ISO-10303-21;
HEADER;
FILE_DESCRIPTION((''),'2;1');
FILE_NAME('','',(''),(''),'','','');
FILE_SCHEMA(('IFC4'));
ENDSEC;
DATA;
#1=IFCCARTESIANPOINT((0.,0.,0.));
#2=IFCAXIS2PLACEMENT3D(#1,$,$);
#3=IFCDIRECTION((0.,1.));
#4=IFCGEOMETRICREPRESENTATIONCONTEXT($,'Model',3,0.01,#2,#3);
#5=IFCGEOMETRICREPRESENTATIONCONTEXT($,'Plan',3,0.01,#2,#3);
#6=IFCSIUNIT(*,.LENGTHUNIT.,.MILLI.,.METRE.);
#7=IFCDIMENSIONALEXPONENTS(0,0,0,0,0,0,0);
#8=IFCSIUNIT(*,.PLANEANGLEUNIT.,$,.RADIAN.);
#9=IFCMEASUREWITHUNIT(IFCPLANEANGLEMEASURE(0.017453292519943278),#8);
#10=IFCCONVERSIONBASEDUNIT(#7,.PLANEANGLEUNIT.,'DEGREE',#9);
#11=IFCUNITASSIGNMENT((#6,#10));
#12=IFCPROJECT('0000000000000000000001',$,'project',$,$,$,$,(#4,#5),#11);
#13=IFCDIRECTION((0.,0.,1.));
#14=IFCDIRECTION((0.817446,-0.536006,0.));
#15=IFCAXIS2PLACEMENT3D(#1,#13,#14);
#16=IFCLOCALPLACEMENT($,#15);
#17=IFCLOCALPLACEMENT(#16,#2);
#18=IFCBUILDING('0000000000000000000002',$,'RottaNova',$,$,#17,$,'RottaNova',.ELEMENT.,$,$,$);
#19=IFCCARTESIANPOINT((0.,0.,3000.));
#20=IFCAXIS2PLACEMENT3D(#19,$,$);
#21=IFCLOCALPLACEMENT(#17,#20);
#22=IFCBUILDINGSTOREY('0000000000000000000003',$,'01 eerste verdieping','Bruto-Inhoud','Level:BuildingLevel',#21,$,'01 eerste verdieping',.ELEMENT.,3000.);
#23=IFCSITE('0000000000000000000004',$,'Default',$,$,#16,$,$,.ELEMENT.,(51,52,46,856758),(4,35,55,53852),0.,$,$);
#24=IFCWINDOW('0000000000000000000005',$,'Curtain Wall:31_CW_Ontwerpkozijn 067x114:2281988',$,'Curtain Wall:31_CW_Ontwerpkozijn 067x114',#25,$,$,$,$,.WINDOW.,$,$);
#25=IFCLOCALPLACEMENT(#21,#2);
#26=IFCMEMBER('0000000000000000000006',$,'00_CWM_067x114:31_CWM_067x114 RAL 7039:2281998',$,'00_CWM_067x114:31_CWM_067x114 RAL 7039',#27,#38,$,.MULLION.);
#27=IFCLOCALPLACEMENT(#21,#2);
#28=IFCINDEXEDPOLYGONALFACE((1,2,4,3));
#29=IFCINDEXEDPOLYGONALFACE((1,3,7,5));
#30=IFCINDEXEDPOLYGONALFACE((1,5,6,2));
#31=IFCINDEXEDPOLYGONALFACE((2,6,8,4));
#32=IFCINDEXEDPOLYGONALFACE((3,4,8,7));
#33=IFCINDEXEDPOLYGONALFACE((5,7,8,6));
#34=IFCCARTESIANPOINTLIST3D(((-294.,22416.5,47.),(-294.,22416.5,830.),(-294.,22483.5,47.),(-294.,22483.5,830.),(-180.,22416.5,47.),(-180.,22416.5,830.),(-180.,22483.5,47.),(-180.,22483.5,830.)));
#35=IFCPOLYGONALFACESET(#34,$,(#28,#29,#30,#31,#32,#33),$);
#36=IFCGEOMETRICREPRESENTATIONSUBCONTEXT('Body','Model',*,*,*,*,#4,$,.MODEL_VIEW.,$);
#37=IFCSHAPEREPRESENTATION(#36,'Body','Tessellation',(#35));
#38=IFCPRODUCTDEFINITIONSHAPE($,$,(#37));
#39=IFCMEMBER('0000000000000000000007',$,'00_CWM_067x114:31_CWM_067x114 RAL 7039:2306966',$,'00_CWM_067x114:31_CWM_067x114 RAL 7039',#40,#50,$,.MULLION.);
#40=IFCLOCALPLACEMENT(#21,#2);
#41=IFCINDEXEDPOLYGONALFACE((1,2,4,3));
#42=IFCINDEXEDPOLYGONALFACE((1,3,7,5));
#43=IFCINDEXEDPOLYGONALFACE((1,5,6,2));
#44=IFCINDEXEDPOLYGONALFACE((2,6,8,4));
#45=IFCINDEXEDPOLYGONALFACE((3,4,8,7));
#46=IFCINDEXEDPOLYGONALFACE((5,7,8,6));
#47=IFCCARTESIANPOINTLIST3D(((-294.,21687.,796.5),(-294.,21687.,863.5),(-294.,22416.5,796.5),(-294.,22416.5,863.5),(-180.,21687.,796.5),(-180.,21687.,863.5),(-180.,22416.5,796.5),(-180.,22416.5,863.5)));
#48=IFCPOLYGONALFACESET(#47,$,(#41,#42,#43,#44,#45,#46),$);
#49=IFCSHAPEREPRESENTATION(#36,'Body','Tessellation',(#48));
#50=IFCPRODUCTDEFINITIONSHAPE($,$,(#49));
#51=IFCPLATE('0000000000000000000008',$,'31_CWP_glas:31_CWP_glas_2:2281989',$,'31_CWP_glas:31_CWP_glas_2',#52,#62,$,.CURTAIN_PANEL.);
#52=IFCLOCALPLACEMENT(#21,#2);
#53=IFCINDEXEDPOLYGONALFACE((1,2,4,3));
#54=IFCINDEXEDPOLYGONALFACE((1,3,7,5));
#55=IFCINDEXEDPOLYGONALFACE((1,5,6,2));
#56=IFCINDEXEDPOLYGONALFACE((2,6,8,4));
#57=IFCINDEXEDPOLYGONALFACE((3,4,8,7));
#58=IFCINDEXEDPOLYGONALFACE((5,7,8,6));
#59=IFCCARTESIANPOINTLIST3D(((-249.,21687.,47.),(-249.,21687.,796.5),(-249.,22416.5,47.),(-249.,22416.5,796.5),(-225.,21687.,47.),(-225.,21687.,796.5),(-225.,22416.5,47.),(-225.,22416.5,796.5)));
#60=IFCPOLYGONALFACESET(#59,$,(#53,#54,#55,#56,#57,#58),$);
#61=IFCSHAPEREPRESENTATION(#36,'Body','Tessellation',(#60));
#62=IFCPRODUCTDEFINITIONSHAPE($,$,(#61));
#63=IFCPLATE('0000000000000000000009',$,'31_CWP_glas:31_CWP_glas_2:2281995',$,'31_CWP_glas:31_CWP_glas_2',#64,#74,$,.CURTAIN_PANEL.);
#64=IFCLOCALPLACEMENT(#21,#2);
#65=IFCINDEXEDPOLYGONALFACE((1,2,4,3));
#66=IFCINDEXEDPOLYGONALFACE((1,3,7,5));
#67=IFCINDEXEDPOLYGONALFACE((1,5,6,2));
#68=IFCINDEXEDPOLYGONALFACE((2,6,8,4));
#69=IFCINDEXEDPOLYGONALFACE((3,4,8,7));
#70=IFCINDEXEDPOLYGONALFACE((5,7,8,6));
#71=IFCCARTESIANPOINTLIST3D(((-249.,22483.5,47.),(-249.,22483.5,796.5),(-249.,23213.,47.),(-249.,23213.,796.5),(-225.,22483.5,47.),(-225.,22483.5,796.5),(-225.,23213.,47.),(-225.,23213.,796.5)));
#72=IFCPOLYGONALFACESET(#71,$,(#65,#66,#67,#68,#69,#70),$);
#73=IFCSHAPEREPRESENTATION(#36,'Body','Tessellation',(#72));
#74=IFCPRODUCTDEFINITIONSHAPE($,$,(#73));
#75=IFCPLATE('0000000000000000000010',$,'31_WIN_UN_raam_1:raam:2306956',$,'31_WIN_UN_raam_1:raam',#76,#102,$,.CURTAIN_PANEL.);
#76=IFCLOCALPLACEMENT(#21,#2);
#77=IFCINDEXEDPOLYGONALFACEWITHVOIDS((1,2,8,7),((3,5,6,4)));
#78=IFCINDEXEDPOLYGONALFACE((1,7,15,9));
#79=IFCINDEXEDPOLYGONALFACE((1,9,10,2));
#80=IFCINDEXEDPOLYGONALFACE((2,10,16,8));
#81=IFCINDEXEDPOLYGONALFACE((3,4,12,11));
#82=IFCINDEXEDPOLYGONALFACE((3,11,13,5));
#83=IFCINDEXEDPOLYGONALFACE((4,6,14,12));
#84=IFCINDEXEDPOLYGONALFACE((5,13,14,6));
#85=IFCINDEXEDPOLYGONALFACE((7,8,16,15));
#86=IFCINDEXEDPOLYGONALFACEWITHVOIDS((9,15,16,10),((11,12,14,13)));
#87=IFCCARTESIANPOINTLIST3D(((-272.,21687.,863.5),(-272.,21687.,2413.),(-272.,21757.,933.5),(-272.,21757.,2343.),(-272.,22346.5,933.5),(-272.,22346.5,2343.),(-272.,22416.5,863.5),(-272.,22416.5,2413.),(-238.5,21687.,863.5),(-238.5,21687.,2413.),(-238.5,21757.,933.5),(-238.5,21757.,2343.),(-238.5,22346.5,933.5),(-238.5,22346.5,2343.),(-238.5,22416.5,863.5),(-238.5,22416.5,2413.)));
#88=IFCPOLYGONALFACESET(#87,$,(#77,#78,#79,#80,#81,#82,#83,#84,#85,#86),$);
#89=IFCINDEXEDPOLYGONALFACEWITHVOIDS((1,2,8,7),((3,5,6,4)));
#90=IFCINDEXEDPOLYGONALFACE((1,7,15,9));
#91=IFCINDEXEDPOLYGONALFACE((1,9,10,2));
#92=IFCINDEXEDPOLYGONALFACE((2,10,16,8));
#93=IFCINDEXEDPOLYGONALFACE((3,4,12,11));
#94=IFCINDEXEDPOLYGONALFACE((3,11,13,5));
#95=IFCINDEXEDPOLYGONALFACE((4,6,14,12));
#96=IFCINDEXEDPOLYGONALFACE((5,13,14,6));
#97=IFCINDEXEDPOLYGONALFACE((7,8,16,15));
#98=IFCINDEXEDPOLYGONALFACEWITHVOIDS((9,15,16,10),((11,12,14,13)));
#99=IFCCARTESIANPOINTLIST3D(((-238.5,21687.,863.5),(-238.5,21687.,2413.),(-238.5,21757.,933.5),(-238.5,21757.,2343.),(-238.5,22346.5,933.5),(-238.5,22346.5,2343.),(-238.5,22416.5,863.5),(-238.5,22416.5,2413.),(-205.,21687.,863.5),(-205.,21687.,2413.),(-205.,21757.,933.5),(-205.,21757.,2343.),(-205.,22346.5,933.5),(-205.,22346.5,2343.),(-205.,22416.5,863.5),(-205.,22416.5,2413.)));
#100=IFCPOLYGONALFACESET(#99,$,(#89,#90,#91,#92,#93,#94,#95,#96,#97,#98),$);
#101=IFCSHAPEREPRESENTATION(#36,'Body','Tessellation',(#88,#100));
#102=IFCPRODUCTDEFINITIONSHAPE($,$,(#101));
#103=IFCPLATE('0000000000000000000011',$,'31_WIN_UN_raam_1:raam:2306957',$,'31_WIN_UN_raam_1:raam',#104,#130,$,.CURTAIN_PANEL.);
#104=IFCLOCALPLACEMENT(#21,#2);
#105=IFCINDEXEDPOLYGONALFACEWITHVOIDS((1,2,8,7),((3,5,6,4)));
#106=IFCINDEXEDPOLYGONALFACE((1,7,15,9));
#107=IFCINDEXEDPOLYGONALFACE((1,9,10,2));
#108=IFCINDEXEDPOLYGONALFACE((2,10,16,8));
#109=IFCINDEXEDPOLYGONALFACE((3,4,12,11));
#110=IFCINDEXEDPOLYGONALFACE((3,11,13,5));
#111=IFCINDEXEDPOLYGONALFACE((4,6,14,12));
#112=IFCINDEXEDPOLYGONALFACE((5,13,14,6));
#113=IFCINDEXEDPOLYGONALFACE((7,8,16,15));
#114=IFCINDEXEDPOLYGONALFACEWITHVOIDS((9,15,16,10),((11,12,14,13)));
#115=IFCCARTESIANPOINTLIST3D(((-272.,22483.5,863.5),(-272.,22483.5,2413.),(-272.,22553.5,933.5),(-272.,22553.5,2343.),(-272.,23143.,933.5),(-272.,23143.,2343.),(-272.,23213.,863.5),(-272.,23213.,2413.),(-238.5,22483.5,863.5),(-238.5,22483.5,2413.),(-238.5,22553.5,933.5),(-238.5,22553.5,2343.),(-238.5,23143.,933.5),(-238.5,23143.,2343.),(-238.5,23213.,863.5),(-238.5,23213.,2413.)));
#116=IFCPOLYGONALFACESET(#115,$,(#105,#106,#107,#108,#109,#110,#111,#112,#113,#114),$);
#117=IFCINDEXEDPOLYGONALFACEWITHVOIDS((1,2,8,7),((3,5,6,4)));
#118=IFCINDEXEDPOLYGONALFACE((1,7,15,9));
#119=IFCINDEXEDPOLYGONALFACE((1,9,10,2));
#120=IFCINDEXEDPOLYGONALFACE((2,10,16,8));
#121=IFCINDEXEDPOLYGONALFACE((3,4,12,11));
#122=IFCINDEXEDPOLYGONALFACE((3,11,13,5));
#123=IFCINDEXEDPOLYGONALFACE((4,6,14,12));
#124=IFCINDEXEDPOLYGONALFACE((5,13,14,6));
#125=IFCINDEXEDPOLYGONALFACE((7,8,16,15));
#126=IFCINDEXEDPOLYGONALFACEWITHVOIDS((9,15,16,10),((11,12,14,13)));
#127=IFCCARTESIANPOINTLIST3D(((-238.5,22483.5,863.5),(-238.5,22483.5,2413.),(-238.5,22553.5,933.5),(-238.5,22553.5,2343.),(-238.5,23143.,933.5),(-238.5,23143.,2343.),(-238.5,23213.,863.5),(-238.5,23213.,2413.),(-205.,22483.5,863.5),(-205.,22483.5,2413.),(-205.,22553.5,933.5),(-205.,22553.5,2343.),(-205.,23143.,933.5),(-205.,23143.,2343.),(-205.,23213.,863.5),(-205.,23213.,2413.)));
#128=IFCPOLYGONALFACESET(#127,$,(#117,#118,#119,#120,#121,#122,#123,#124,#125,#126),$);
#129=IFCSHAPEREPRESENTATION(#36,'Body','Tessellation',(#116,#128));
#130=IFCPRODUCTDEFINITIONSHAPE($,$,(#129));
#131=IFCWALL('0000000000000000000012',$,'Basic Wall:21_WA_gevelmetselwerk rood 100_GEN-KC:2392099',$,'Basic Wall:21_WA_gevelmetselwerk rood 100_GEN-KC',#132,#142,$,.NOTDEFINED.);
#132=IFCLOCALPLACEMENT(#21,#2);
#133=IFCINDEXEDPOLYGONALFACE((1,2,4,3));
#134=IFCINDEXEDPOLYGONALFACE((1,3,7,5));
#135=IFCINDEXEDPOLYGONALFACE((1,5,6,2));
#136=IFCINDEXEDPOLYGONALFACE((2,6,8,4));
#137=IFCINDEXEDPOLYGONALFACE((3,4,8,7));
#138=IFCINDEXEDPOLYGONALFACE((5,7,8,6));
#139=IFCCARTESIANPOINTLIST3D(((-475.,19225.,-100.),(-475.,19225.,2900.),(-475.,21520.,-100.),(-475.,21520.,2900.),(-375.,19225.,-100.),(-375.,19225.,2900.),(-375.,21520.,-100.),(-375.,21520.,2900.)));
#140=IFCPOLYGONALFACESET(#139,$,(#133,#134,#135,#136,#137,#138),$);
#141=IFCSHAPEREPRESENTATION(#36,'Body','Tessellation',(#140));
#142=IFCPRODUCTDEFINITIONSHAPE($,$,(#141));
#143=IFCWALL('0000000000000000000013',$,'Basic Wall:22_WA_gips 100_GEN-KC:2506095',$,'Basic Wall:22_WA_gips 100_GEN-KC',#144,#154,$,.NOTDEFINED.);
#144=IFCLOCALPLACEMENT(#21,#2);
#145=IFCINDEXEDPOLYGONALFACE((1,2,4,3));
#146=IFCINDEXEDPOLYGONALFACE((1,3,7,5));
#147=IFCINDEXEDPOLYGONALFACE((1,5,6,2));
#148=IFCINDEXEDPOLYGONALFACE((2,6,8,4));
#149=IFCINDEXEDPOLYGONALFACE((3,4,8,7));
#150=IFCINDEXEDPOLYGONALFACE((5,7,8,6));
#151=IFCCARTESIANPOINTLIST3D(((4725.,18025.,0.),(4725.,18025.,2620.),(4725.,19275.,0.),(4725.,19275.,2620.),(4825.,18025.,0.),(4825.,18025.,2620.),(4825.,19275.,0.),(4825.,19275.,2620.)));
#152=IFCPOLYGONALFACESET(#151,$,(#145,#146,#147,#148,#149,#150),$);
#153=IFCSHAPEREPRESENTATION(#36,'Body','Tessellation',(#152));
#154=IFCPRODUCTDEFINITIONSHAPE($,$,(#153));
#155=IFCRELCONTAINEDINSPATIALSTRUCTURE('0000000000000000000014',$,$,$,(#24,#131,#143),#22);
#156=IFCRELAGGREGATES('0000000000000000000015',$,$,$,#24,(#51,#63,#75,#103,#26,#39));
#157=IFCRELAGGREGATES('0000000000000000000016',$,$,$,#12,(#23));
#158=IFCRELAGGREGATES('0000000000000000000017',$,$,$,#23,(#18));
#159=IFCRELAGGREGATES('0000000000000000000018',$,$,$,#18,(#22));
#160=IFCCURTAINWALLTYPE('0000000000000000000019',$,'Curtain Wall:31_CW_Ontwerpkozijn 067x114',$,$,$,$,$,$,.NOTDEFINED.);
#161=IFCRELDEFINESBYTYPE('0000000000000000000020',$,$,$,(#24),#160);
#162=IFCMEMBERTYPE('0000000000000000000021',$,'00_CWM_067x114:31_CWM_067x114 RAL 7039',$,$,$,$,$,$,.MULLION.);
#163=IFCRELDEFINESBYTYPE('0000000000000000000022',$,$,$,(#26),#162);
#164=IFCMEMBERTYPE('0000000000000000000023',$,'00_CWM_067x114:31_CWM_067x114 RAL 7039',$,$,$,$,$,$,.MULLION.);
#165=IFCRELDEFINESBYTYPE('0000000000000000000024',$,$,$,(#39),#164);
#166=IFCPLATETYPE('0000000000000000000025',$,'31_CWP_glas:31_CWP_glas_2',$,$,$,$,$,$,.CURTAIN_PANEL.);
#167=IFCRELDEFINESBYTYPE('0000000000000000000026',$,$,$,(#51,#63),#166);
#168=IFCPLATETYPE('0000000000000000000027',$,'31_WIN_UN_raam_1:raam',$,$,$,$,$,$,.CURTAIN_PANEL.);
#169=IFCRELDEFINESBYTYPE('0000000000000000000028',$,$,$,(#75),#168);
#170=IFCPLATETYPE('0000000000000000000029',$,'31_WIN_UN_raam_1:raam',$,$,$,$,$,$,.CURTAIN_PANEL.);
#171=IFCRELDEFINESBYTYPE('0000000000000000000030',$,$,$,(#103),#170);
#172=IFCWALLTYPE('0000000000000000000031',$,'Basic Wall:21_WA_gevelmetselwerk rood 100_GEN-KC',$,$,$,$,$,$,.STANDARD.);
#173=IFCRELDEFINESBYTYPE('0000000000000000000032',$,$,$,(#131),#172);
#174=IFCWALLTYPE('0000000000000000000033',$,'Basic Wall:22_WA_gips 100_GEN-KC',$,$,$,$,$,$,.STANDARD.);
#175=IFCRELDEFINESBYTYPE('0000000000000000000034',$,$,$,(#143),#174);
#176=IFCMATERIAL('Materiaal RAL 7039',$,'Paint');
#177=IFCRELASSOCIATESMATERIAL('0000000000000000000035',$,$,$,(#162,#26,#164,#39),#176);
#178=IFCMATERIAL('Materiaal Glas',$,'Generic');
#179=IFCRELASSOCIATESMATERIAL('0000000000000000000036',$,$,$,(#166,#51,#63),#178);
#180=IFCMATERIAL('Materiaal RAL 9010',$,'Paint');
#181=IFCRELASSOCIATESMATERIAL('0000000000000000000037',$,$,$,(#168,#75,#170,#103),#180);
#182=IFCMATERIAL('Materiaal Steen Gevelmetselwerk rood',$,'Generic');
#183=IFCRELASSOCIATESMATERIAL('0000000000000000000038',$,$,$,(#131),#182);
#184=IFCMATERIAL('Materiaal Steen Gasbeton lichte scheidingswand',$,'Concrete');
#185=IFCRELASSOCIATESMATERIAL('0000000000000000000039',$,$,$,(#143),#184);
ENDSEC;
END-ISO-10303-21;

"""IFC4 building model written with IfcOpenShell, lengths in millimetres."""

from ifc_helpers import new_model, entity, si_unit, converted_unit, direction, frame, origin, place, context, subcontext, project, spatial, indexed_curve, outline, extrude, source, transform, mapped, material, type_object, type_shapes, element, aggregate, save


model = new_model("IFC4")

# Units and contexts
model_context = context("Model", 3, precision=0.01, world=origin(), true_north=direction((0.0, 1.0)))
plan_context = context("Plan", 3, precision=0.01, world=origin(), true_north=direction((0.0, 1.0)))
body_context = subcontext(model_context, "Body", "Model", "MODEL_VIEW")
ifc_project = project(units=[si_unit("LENGTHUNIT", "METRE", prefix="MILLI"), converted_unit("PLANEANGLEUNIT", "DEGREE", entity("IfcPlaneAngleMeasure", 0.017453292519943278), si_unit("PLANEANGLEUNIT", "RADIAN"), dimensions=[0, 0, 0, 0, 0, 0, 0])], contexts=[model_context, plan_context])

# Site, building, storey
site_placement = place(None, frame((0.0, 0.0, 0.0), z_axis=(0.0, 0.0, 1.0), x_axis=(0.817446, -0.536006, 0.0)))
site = spatial("IfcSite", under=ifc_project, at=site_placement, Name="Default", CompositionType="ELEMENT", RefLatitude=(51, 52, 46, 856758), RefLongitude=(4, 35, 55, 53852), RefElevation=0.0)
building_placement = place(site_placement, origin())
building = spatial("IfcBuilding", under=site, at=building_placement, Name="RottaNova", LongName="RottaNova", CompositionType="ELEMENT")
storey_placement = place(building_placement, frame((0.0, 0.0, 3000.0)))
storey = spatial("IfcBuildingStorey", under=building, at=storey_placement, Name="01 eerste verdieping", Description="Bruto-Inhoud", ObjectType="Level:BuildingLevel", LongName="01 eerste verdieping", CompositionType="ELEMENT", Elevation=3000.0)

# Shared definitions
curtain_wall_type = type_object("IfcCurtainWallType", Name="Curtain Wall:31_CW_Ontwerpkozijn 067x114", PredefinedType="NOTDEFINED")
ifc_material_1 = material(Name="Materiaal RAL 7039", Category="Paint")

# Window
window_1_placement = place(storey_placement, frame((0.0, 0.0, -3000.0)))
window_1 = element("IfcWindow", 1, at=window_1_placement, inside=storey, type_object=curtain_wall_type, Name="Curtain Wall:31_CW_Ontwerpkozijn 067x114:2281988", ObjectType="Curtain Wall:31_CW_Ontwerpkozijn 067x114", PredefinedType="WINDOW")

# Members
member_type_1 = type_object("IfcMemberType", Name="00_CWM_067x114:31_CWM_067x114 RAL 7039", PredefinedType="MULLION", material=ifc_material_1)
shared_shape_1 = source(origin(), body_context, "Body", "SweptSolid", [
    extrude(outline(indexed_curve([(-33.5, -57.0), (33.5, -57.0), (33.5, 57.0), (-33.5, 57.0), (-33.5, -57.0)], self_intersect=False)), frame((0.0, -57.0, -783.0), z_axis=(0.0, 0.0, 1.0), x_axis=(-1.0, 0.0, 0.0)), (0.0, 0.0, 1.0), 783.0),
])
type_shapes(member_type_1, [shared_shape_1])
member_1_placement = place(window_1_placement, frame((-180.0, 22450.0, 3047.0), z_axis=(0.0, 0.0, -1.0), x_axis=(0.0, 1.0, 0.0)))
member_1 = element("IfcMember", 2, at=member_1_placement, type_object=member_type_1, material=ifc_material_1, Name="00_CWM_067x114:31_CWM_067x114 RAL 7039:2281998", ObjectType="00_CWM_067x114:31_CWM_067x114 RAL 7039", PredefinedType="MULLION", context=body_context, shape_type="MappedRepresentation", body=[
    mapped(shared_shape_1, transform((0.0, 0.0, 0.0), scale=1.0)),
])
member_type_2 = type_object("IfcMemberType", Name="00_CWM_067x114:31_CWM_067x114 RAL 7039", PredefinedType="MULLION", material=ifc_material_1)
shared_shape_2 = source(origin(), body_context, "Body", "SweptSolid", [
    extrude(outline(indexed_curve([(-33.5, -57.0), (33.5, -57.0), (33.5, 57.0), (-33.5, 57.0), (-33.5, -57.0)], self_intersect=False)), frame((0.0, -57.0, -729.5), z_axis=(0.0, 0.0, 1.0), x_axis=(-1.0, 0.0, 0.0)), (0.0, 0.0, 1.0), 729.5),
])
type_shapes(member_type_2, [shared_shape_2])
member_2_placement = place(window_1_placement, frame((-180.0, 22416.5, 3830.0), z_axis=(0.0, 1.0, 0.0), x_axis=(0.0, 0.0, 1.0)))
member_2 = element("IfcMember", 3, at=member_2_placement, type_object=member_type_2, material=ifc_material_1, Name="00_CWM_067x114:31_CWM_067x114 RAL 7039:2306966", ObjectType="00_CWM_067x114:31_CWM_067x114 RAL 7039", PredefinedType="MULLION", context=body_context, shape_type="MappedRepresentation", body=[
    mapped(shared_shape_2, transform((0.0, 0.0, 0.0), scale=1.0)),
])

# Plates
ifc_material_2 = material(Name="Materiaal Glas", Category="Generic")
plate_type_1 = type_object("IfcPlateType", Name="31_CWP_glas:31_CWP_glas_2", PredefinedType="CURTAIN_PANEL", material=ifc_material_2)
shared_shape_3 = source(origin(), body_context, "Body", "SweptSolid", [
    extrude(outline(indexed_curve([(-12.0, -364.7), (12.0, -364.7), (12.0, 364.7), (-12.0, 364.7), (-12.0, -364.7)], self_intersect=False)), frame((0.0, 57.0, 0.0), z_axis=(0.0, 0.0, 1.0), x_axis=(0.0, 1.0, 0.0)), (0.0, 0.0, 1.0), 749.5),
])
type_shapes(plate_type_1, [shared_shape_3])
plate_1_placement = place(window_1_placement, frame((-180.0, 22051.7, 3047.0), z_axis=(0.0, 0.0, 1.0), x_axis=(0.0, 1.0, 0.0)))
plate_1 = element("IfcPlate", 4, at=plate_1_placement, type_object=plate_type_1, material=ifc_material_2, Name="31_CWP_glas:31_CWP_glas_2:2281989", ObjectType="31_CWP_glas:31_CWP_glas_2", PredefinedType="CURTAIN_PANEL", context=body_context, shape_type="MappedRepresentation", body=[
    mapped(shared_shape_3, transform((0.0, 0.0, 0.0), scale=1.0)),
])
plate_2_placement = place(window_1_placement, frame((-180.0, 22848.2, 3047.0), z_axis=(0.0, 0.0, 1.0), x_axis=(0.0, 1.0, 0.0)))
plate_2 = element("IfcPlate", 5, at=plate_2_placement, type_object=plate_type_1, material=ifc_material_2, Name="31_CWP_glas:31_CWP_glas_2:2281995", ObjectType="31_CWP_glas:31_CWP_glas_2", PredefinedType="CURTAIN_PANEL", context=body_context, shape_type="MappedRepresentation", body=[
    mapped(shared_shape_3, transform((0.0, 0.0, 0.0), scale=1.0)),
])
ifc_material_3 = material(Name="Materiaal RAL 9010", Category="Paint")
plate_type_2 = type_object("IfcPlateType", Name="31_WIN_UN_raam_1:raam", PredefinedType="CURTAIN_PANEL", material=ifc_material_3)
shared_shape_4 = source(origin(), body_context, "Body", "SweptSolid", [
    extrude(outline(indexed_curve([(-364.7, -774.7), (364.7, -774.7), (364.7, 774.7), (-364.7, 774.7), (-364.7, -774.7)], self_intersect=False), holes=[indexed_curve([(-294.7, 704.7), (294.7, 704.7), (294.7, -704.8), (-294.7, -704.8), (-294.7, 704.7)], self_intersect=False)]), frame((0.0, 58.5, 774.8), z_axis=(0.0, 1.0, 0.0), x_axis=(1.0, 0.0, 0.0)), (0.0, 0.0, 1.0), 33.5),
    extrude(outline(indexed_curve([(-364.7, -774.7), (364.7, -774.7), (364.7, 774.7), (-364.7, 774.7), (-364.7, -774.7)], self_intersect=False), holes=[indexed_curve([(-294.7, 704.7), (294.7, 704.7), (294.7, -704.8), (-294.7, -704.8), (-294.7, 704.7)], self_intersect=False)]), frame((0.0, 25.0, 774.8), z_axis=(0.0, 1.0, 0.0), x_axis=(1.0, 0.0, 0.0)), (0.0, 0.0, 1.0), 33.5),
])
type_shapes(plate_type_2, [shared_shape_4])
plate_3_placement = place(window_1_placement, frame((-180.0, 22051.7, 3863.5), z_axis=(0.0, 0.0, 1.0), x_axis=(0.0, 1.0, 0.0)))
plate_3 = element("IfcPlate", 6, at=plate_3_placement, type_object=plate_type_2, material=ifc_material_3, Name="31_WIN_UN_raam_1:raam:2306956", ObjectType="31_WIN_UN_raam_1:raam", PredefinedType="CURTAIN_PANEL", context=body_context, shape_type="MappedRepresentation", body=[
    mapped(shared_shape_4, transform((0.0, 0.0, 0.0), scale=1.0)),
])
plate_type_3 = type_object("IfcPlateType", Name="31_WIN_UN_raam_1:raam", PredefinedType="CURTAIN_PANEL", material=ifc_material_3)
shared_shape_5 = source(origin(), body_context, "Body", "SweptSolid", [
    extrude(outline(indexed_curve([(-364.7, -774.7), (364.7, -774.7), (364.7, 774.7), (-364.7, 774.7), (-364.7, -774.7)], self_intersect=False), holes=[indexed_curve([(-294.7, 704.7), (294.7, 704.7), (294.7, -704.8), (-294.7, -704.8), (-294.7, 704.7)], self_intersect=False)]), frame((0.0, 58.5, 774.8), z_axis=(0.0, 1.0, 0.0), x_axis=(1.0, 0.0, 0.0)), (0.0, 0.0, 1.0), 33.5),
    extrude(outline(indexed_curve([(-364.7, -774.7), (364.7, -774.7), (364.7, 774.7), (-364.7, 774.7), (-364.7, -774.7)], self_intersect=False), holes=[indexed_curve([(-294.7, 704.7), (294.7, 704.7), (294.7, -704.8), (-294.7, -704.8), (-294.7, 704.7)], self_intersect=False)]), frame((0.0, 25.0, 774.8), z_axis=(0.0, 1.0, 0.0), x_axis=(1.0, 0.0, 0.0)), (0.0, 0.0, 1.0), 33.5),
])
type_shapes(plate_type_3, [shared_shape_5])
plate_4_placement = place(window_1_placement, frame((-180.0, 22848.2, 3863.5), z_axis=(0.0, 0.0, 1.0), x_axis=(0.0, 1.0, 0.0)))
plate_4 = element("IfcPlate", 7, at=plate_4_placement, type_object=plate_type_3, material=ifc_material_3, Name="31_WIN_UN_raam_1:raam:2306957", ObjectType="31_WIN_UN_raam_1:raam", PredefinedType="CURTAIN_PANEL", context=body_context, shape_type="MappedRepresentation", body=[
    mapped(shared_shape_5, transform((0.0, 0.0, 0.0), scale=1.0)),
])
aggregate(window_1, [plate_1, plate_2, plate_3, plate_4, member_1, member_2])

# Walls
ifc_material_4 = material(Name="Materiaal Steen Gevelmetselwerk rood", Category="Generic")
wall_type_1 = type_object("IfcWallType", Name="Basic Wall:21_WA_gevelmetselwerk rood 100_GEN-KC", PredefinedType="STANDARD")
wall_1_placement = place(storey_placement, frame((-425.0, 21520.0, -100.0), z_axis=(0.0, 0.0, 1.0), x_axis=(0.0, -1.0, 0.0)))
element("IfcWall", 8, at=wall_1_placement, inside=storey, type_object=wall_type_1, material=ifc_material_4, Name="Basic Wall:21_WA_gevelmetselwerk rood 100_GEN-KC:2392099", ObjectType="Basic Wall:21_WA_gevelmetselwerk rood 100_GEN-KC", PredefinedType="NOTDEFINED", context=body_context, shape_type="SweptSolid", body=[
    extrude(outline(indexed_curve([(2295.0, 50.0), (0.0, 50.0), (0.0, -50.0), (2295.0, -50.0), (2295.0, 50.0)], self_intersect=False)), origin(), (0.0, 0.0, 1.0), 3000.0),
])
ifc_material_5 = material(Name="Materiaal Steen Gasbeton lichte scheidingswand", Category="Concrete")
wall_type_2 = type_object("IfcWallType", Name="Basic Wall:22_WA_gips 100_GEN-KC", PredefinedType="STANDARD")
wall_2_placement = place(storey_placement, frame((4775.0, 19275.0, 0.0), z_axis=(0.0, 0.0, 1.0), x_axis=(0.0, -1.0, 0.0)))
element("IfcWall", 9, at=wall_2_placement, inside=storey, type_object=wall_type_2, material=ifc_material_5, Name="Basic Wall:22_WA_gips 100_GEN-KC:2506095", ObjectType="Basic Wall:22_WA_gips 100_GEN-KC", PredefinedType="NOTDEFINED", context=body_context, shape_type="SweptSolid", body=[
    extrude(outline(indexed_curve([(1250.0, 50.0), (0.0, 50.0), (0.0, -50.0), (1250.0, -50.0), (1250.0, 50.0)], self_intersect=False)), origin(), (0.0, 0.0, 1.0), 2620.0),
])

save(model, "model.ifc")
